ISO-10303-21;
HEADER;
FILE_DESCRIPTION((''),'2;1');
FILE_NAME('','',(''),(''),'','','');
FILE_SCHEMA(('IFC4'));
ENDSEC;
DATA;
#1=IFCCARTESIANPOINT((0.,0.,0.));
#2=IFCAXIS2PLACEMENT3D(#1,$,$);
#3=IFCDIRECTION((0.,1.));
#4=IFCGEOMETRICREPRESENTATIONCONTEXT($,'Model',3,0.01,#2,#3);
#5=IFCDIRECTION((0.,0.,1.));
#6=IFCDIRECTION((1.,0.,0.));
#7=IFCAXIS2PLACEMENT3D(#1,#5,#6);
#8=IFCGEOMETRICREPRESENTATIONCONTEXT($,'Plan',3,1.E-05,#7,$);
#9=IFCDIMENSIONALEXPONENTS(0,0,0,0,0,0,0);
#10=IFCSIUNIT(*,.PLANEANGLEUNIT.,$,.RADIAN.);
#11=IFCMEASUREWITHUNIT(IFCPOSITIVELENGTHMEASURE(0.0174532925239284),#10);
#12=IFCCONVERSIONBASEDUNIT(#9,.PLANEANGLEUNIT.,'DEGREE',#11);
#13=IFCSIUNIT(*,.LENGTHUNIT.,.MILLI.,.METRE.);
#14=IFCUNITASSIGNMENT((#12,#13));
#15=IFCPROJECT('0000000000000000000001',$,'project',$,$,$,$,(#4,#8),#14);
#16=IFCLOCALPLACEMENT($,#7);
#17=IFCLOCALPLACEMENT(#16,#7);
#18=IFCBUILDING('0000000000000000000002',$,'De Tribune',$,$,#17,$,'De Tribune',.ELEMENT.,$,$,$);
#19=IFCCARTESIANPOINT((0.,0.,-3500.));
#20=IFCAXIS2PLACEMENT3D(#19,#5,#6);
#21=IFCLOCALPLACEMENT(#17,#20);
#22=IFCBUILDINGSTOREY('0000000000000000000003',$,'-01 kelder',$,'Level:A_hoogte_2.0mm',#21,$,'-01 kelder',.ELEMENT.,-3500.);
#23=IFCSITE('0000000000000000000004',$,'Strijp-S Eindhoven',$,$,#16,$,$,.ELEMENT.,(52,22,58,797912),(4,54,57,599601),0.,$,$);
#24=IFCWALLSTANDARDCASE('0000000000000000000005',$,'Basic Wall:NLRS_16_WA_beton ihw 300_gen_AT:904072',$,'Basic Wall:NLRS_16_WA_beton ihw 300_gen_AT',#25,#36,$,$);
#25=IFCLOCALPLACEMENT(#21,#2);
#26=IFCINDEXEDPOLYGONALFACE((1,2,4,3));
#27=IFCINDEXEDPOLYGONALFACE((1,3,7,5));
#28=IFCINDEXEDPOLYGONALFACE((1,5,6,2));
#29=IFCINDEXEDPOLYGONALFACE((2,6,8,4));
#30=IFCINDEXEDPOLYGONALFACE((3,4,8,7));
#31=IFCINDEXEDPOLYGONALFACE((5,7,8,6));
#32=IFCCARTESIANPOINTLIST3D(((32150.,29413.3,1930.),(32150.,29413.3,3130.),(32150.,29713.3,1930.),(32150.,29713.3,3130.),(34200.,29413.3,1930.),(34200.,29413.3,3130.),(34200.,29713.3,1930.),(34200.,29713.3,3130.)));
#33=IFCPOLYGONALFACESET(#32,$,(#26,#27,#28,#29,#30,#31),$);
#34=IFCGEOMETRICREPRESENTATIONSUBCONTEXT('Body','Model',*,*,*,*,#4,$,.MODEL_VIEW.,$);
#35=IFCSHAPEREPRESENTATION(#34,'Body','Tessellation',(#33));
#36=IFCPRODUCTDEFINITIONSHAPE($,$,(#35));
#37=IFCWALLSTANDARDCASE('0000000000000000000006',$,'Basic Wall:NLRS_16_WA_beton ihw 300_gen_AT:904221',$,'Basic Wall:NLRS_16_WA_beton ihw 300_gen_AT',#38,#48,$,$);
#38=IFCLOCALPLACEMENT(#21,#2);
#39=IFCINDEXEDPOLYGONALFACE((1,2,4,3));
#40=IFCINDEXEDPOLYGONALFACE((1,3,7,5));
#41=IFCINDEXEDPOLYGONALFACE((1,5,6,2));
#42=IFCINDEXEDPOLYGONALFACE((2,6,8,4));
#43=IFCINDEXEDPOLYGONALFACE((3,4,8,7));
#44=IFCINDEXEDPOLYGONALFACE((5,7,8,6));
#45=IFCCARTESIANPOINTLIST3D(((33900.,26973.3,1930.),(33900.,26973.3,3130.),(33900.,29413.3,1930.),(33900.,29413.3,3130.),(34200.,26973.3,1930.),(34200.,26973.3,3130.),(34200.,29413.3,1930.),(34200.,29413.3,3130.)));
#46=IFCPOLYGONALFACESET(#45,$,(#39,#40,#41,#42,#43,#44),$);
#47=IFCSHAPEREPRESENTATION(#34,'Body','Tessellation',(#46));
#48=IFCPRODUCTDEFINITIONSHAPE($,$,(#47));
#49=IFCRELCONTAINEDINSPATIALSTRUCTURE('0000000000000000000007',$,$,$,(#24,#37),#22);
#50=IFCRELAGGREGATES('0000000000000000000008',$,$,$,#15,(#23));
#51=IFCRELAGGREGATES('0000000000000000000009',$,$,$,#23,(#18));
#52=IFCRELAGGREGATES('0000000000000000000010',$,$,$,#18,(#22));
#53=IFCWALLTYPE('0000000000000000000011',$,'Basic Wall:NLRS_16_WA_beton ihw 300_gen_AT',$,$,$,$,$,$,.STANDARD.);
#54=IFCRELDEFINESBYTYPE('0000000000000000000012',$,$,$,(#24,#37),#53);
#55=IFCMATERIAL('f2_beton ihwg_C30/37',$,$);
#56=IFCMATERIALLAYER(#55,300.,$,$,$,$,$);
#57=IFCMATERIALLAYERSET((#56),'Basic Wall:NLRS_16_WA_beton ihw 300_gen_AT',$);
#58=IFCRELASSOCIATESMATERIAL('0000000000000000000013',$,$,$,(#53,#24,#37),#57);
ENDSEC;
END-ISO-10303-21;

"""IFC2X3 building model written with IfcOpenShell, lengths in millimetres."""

from ifc_helpers import new_model, entity, si_unit, converted_unit, direction, frame, frame_2d, origin, origin_with_axes, place, context, subcontext, project, spatial, rectangle, extrude, material, layer, layer_set, layer_usage, type_object, element, save


model = new_model("IFC2X3")

# Units and contexts
model_context = context("Model", 3, precision=0.01, world=origin(), true_north=direction((0.0, 1.0)))
plan_context = context("Plan", 3, precision=1e-05, world=origin_with_axes())
body_context = subcontext(model_context, "Body", "Model", "MODEL_VIEW")
ifc_project = project(units=[converted_unit("PLANEANGLEUNIT", "DEGREE", entity("IfcPositiveLengthMeasure", 0.0174532925239284), si_unit("PLANEANGLEUNIT", "RADIAN"), dimensions=[0, 0, 0, 0, 0, 0, 0]), si_unit("LENGTHUNIT", "METRE", prefix="MILLI")], contexts=[model_context, plan_context])

# Site, building, storey
site_placement = place(None, origin_with_axes())
site = spatial("IfcSite", under=ifc_project, at=site_placement, Name="Strijp-S Eindhoven", CompositionType="ELEMENT", RefLatitude=(52, 22, 58, 797912), RefLongitude=(4, 54, 57, 599601), RefElevation=0.0)
building_placement = place(site_placement, origin_with_axes())
building = spatial("IfcBuilding", under=site, at=building_placement, Name="De Tribune", LongName="De Tribune", CompositionType="ELEMENT")
storey_placement = place(building_placement, frame((0.0, 0.0, -3500.0), z_axis=(0.0, 0.0, 1.0), x_axis=(1.0, 0.0, 0.0)))
storey = spatial("IfcBuildingStorey", under=building, at=storey_placement, Name="-01 kelder", ObjectType="Level:A_hoogte_2.0mm", LongName="-01 kelder", CompositionType="ELEMENT", Elevation=-3500.0)

# Walls
ifc_material = material(Name="f2_beton ihwg_C30/37")
ifc_layer = layer(ifc_material, 300.0)
ifc_layer_set = layer_set([ifc_layer], Name="Basic Wall:NLRS_16_WA_beton ihw 300_gen_AT")
ifc_layer_usage_1 = layer_usage(ifc_layer_set, "AXIS2", "POSITIVE", -150.0)
wall_type = type_object("IfcWallType", Name="Basic Wall:NLRS_16_WA_beton ihw 300_gen_AT", PredefinedType="STANDARD", material=ifc_layer_set)
wall_1_placement = place(storey_placement, frame((32150.0, 29563.3, 1930.0), z_axis=(0.0, 0.0, 1.0), x_axis=(1.0, 0.0, 0.0)))
element("IfcWallStandardCase", 1, at=wall_1_placement, inside=storey, type_object=wall_type, material=ifc_layer_usage_1, Name="Basic Wall:NLRS_16_WA_beton ihw 300_gen_AT:904072", ObjectType="Basic Wall:NLRS_16_WA_beton ihw 300_gen_AT", context=body_context, shape_type="SweptSolid", body=[
    extrude(rectangle(XDim=2050.0, YDim=300.0, at=frame_2d((1025.0, 0.0), x_axis=(-1.0, 0.0))), origin(), (0.0, 0.0, 1.0), 1200.0),
])
ifc_layer_usage_2 = layer_usage(ifc_layer_set, "AXIS2", "NEGATIVE", 150.0)
wall_2_placement = place(storey_placement, frame((34050.0, 26973.3, 1930.0), z_axis=(0.0, 0.0, 1.0), x_axis=(0.0, 1.0, 0.0)))
element("IfcWallStandardCase", 2, at=wall_2_placement, inside=storey, type_object=wall_type, material=ifc_layer_usage_2, Name="Basic Wall:NLRS_16_WA_beton ihw 300_gen_AT:904221", ObjectType="Basic Wall:NLRS_16_WA_beton ihw 300_gen_AT", context=body_context, shape_type="SweptSolid", body=[
    extrude(rectangle(XDim=2440.0, YDim=300.0, at=frame_2d((1220.0, 0.0), x_axis=(-1.0, 0.0))), origin(), (0.0, 0.0, 1.0), 1200.0),
])

save(model, "model.ifc")
